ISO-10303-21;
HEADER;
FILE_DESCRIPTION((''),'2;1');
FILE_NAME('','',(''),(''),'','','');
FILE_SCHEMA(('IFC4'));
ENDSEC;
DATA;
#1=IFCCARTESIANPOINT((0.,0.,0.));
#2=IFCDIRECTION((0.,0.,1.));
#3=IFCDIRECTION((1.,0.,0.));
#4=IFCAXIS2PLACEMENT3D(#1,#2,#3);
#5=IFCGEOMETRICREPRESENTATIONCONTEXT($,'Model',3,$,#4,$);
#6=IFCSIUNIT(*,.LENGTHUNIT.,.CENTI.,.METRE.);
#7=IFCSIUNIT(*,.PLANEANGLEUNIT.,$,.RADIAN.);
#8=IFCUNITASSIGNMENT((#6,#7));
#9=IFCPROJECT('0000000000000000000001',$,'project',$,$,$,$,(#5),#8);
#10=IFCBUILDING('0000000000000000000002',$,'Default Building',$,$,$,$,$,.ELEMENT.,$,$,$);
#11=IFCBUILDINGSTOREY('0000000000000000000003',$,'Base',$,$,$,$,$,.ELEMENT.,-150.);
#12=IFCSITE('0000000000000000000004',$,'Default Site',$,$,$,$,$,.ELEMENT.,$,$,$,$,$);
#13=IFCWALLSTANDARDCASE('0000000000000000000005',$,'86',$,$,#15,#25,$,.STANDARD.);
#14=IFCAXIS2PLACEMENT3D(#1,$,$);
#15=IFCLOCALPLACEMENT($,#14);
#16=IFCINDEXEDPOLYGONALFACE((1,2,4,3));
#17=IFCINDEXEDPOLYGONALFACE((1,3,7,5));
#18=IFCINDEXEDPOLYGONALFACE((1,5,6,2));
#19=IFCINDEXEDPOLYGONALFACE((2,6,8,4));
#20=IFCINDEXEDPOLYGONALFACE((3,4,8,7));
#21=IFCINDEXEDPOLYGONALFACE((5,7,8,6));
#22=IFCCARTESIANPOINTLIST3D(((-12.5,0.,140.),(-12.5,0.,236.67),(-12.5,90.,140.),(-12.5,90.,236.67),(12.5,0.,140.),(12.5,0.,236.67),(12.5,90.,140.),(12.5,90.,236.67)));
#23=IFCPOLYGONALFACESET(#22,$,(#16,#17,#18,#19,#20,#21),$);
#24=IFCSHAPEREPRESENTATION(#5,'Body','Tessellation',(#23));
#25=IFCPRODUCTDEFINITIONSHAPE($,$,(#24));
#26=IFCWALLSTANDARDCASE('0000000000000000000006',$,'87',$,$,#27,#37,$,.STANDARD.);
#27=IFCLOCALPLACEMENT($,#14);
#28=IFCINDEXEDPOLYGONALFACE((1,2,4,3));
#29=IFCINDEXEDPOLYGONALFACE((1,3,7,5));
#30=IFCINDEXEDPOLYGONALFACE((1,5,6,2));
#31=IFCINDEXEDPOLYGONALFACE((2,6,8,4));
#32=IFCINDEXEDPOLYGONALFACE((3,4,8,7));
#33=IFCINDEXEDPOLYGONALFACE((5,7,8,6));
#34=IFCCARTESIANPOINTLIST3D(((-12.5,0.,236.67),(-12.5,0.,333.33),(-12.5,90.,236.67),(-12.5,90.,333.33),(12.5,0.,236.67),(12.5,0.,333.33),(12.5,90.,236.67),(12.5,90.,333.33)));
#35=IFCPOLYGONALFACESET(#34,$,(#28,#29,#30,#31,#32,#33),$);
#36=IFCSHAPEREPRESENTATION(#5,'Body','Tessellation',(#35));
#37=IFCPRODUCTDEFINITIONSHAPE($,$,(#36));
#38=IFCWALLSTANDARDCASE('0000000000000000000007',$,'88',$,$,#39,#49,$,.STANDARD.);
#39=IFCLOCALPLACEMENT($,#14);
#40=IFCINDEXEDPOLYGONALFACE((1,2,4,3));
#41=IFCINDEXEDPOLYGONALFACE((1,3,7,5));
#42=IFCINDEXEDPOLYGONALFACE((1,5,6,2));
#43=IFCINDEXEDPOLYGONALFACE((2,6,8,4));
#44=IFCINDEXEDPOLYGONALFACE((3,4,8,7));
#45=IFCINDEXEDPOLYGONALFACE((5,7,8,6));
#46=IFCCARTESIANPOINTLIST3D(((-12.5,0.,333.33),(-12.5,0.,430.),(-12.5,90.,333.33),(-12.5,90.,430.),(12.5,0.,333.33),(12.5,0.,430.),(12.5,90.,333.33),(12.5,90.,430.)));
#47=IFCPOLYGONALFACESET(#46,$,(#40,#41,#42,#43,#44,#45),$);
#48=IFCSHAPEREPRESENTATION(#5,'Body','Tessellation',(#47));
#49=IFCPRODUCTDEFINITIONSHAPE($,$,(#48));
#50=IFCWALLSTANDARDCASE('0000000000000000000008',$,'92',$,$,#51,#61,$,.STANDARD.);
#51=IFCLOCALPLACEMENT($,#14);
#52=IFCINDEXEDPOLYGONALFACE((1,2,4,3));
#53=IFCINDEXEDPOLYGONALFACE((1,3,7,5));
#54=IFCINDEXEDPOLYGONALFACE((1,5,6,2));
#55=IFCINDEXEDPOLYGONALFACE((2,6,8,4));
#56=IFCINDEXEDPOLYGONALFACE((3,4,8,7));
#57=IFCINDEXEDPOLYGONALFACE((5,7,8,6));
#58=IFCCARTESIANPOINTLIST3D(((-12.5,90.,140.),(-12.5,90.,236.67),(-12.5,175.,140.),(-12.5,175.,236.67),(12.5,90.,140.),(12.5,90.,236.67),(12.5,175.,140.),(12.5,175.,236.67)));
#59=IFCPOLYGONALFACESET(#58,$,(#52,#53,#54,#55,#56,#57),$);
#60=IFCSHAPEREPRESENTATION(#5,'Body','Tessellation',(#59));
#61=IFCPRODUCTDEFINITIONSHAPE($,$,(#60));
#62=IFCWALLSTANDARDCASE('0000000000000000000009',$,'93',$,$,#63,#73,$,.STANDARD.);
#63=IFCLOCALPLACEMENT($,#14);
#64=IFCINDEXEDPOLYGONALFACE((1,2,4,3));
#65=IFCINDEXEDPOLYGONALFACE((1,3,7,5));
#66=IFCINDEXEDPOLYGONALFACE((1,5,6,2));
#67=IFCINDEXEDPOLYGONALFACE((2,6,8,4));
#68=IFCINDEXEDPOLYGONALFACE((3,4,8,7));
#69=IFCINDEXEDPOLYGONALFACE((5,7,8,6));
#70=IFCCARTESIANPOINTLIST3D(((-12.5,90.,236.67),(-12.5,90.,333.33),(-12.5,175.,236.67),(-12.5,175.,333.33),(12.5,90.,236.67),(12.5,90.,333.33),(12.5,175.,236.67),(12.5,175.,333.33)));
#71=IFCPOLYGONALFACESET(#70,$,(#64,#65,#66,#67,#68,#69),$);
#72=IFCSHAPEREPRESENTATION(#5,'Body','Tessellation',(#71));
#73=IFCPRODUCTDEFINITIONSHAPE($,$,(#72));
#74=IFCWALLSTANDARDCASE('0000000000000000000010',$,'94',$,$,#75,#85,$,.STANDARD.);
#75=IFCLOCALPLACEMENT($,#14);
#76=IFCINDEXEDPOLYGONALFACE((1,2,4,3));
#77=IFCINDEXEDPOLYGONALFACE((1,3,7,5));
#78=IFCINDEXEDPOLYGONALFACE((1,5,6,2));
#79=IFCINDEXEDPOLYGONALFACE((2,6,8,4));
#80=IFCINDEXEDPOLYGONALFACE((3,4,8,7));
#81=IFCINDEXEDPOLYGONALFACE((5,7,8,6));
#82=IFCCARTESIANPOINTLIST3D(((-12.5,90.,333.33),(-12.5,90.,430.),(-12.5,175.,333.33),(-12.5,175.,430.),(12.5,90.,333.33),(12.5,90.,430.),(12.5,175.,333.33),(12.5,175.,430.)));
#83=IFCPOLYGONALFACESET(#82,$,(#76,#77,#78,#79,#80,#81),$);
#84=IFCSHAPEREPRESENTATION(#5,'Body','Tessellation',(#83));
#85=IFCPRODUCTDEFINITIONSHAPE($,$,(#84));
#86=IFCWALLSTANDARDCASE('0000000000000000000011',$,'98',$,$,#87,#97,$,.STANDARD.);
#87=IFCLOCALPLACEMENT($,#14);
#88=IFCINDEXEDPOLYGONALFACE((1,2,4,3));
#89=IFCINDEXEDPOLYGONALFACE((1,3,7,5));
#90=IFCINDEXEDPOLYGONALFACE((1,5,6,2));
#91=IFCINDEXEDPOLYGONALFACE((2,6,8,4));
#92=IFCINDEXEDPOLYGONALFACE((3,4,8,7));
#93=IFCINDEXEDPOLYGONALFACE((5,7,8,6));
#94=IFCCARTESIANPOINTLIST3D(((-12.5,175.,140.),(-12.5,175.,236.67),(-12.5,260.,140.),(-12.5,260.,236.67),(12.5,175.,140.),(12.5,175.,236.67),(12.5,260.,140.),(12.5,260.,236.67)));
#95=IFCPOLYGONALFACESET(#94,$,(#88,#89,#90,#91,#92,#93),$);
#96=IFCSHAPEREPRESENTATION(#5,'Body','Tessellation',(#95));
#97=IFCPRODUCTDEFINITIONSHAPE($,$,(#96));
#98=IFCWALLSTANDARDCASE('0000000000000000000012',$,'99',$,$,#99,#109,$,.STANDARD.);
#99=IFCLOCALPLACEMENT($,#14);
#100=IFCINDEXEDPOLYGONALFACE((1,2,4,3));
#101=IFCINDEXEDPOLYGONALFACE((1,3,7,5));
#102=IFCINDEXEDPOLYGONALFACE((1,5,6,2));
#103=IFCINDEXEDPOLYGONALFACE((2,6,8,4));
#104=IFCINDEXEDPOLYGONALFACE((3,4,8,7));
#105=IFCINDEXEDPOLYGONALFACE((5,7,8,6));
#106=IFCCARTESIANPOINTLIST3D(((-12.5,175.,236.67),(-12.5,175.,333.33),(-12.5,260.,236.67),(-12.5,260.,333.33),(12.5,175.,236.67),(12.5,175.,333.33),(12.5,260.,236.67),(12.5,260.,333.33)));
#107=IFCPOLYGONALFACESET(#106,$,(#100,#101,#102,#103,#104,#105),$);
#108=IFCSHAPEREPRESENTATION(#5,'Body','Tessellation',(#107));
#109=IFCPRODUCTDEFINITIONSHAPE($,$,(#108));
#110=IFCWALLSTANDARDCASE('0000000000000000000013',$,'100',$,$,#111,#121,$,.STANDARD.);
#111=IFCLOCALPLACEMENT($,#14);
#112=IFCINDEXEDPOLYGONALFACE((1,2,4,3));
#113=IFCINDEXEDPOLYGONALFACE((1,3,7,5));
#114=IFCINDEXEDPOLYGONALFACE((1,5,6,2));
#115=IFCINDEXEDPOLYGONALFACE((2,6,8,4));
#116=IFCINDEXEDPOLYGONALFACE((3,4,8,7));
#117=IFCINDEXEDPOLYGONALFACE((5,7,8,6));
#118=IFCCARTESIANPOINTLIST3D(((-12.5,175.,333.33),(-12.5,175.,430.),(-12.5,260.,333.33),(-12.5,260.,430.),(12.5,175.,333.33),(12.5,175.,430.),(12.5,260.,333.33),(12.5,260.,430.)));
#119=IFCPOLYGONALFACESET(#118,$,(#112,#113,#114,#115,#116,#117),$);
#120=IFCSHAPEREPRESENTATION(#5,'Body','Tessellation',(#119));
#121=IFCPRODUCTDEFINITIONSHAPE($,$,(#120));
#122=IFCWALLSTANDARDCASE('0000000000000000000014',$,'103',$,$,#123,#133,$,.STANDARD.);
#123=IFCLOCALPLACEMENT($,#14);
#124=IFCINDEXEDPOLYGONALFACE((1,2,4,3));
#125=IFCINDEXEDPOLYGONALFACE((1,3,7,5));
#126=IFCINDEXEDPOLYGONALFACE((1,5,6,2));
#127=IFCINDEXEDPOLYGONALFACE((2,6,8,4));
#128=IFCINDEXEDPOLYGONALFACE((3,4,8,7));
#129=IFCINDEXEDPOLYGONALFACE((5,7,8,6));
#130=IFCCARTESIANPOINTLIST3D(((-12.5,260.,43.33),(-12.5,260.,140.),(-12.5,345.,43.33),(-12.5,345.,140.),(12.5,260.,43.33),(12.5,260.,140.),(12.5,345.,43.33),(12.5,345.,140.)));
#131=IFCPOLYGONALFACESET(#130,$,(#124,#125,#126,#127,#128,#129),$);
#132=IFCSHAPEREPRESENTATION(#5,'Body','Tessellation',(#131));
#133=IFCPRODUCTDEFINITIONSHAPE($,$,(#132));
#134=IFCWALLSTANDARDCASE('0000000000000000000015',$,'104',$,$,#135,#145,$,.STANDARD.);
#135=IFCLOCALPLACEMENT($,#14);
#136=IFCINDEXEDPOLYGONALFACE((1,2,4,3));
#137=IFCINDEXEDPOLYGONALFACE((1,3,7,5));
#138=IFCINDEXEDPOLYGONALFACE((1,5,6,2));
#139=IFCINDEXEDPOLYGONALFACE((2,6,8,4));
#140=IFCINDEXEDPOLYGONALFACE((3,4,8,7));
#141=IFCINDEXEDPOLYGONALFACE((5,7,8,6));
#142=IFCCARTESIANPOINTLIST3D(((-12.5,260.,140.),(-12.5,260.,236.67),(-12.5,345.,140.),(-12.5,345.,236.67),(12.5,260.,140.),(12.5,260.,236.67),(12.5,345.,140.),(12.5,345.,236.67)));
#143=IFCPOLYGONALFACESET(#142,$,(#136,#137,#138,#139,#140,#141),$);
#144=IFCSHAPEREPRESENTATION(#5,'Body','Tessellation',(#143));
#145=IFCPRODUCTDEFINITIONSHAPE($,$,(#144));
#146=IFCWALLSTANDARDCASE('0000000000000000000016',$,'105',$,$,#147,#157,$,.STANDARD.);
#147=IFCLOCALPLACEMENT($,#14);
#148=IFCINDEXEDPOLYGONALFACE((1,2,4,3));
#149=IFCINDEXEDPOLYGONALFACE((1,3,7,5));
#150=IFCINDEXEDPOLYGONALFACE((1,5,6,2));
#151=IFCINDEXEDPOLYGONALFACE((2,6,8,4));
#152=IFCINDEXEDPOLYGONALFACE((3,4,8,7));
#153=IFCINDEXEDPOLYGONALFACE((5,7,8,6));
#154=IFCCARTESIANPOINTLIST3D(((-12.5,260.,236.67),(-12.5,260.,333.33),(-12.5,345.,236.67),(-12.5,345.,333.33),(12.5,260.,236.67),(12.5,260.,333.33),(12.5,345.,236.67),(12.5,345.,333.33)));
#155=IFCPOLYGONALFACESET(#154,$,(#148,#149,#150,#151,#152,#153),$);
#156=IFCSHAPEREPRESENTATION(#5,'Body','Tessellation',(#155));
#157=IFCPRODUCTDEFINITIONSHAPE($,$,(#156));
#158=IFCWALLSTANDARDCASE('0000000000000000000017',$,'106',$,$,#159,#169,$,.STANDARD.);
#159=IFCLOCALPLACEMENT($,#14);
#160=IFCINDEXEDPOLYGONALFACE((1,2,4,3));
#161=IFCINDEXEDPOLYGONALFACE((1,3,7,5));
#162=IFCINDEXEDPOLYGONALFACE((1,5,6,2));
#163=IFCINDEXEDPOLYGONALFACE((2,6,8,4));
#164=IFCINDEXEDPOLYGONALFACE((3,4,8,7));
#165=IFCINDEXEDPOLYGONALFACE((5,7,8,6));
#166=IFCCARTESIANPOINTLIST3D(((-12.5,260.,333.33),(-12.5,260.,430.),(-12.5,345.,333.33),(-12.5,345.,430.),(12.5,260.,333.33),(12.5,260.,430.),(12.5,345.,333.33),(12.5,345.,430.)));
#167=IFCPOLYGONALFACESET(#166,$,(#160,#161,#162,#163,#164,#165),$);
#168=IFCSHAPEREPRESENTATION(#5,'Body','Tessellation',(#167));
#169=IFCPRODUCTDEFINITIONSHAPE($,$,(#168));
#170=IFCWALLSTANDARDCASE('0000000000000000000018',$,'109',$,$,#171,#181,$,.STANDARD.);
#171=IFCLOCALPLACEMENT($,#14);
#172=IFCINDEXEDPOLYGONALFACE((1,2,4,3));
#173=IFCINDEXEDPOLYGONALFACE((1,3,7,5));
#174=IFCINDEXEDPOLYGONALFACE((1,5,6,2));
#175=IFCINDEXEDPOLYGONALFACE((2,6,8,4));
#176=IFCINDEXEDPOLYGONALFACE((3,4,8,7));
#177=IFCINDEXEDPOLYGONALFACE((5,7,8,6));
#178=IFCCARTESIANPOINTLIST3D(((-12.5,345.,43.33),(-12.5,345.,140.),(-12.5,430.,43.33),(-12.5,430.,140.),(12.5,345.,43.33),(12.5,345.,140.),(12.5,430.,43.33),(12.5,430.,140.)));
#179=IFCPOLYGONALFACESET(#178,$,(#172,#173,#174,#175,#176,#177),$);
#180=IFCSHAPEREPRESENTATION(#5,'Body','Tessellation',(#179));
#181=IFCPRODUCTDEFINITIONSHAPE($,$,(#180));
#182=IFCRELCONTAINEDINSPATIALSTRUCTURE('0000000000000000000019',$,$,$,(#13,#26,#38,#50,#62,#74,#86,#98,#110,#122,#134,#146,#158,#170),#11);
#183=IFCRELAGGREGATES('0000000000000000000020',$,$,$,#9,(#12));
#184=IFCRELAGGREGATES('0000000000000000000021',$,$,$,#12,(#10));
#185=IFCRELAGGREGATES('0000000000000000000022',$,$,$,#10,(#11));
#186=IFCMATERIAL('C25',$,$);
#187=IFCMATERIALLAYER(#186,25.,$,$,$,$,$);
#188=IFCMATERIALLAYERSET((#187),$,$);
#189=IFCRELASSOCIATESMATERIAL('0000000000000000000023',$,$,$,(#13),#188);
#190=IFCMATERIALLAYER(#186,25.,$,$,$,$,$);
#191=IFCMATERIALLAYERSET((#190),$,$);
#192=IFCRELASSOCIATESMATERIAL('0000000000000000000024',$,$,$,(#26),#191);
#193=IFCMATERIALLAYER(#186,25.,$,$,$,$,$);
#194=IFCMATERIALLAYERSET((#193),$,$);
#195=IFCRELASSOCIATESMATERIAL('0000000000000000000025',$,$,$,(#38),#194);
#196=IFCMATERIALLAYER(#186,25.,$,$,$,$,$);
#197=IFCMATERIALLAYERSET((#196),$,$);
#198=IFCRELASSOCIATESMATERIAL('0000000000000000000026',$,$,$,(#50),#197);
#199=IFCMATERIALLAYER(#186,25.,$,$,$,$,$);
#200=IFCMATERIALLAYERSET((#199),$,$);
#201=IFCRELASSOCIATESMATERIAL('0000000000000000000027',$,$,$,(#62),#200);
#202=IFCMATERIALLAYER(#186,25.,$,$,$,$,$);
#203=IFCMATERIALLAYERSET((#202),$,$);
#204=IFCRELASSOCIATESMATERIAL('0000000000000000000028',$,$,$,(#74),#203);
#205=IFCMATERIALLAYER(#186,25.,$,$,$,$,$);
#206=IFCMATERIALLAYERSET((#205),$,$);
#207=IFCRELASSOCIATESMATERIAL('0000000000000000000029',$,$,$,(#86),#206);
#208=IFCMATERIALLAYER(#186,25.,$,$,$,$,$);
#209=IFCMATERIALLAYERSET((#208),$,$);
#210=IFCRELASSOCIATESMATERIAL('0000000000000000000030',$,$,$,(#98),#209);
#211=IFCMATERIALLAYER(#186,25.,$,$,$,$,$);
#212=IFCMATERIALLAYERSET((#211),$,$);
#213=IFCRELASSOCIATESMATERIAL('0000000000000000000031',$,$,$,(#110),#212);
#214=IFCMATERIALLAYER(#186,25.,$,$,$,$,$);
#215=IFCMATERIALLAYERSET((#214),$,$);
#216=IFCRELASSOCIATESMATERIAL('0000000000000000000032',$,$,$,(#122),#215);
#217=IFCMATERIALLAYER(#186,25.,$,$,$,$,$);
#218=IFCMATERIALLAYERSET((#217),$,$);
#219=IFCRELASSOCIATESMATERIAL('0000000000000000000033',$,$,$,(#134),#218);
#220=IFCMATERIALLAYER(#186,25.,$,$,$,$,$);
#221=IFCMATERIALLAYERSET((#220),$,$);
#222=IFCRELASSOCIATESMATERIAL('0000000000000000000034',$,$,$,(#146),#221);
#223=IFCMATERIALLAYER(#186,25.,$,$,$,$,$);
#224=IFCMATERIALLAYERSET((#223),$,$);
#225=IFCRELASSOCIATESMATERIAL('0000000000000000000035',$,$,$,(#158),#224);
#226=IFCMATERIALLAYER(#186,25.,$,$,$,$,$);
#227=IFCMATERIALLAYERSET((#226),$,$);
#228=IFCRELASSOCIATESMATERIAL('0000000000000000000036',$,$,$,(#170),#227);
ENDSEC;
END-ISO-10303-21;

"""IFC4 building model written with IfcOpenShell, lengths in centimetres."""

from ifc_helpers import new_model, si_unit, frame, origin_with_axes, origin_2d_with_axis, place, context, project, spatial, rectangle, extrude, material, layer, layer_set, layer_usage, element, save


model = new_model("IFC4")

# Units and contexts
model_context = context("Model", 3, world=origin_with_axes())
ifc_project = project(units=[si_unit("LENGTHUNIT", "METRE", prefix="CENTI"), si_unit("PLANEANGLEUNIT", "RADIAN")], contexts=[model_context])

# Site, building, storey
site = spatial("IfcSite", under=ifc_project, Name="Default Site", CompositionType="ELEMENT")
building = spatial("IfcBuilding", under=site, Name="Default Building", CompositionType="ELEMENT")
storey = spatial("IfcBuildingStorey", under=building, Name="Base", CompositionType="ELEMENT", Elevation=-150.0)

# Walls
ifc_material = material(Name="C25")
ifc_layer_1 = layer(ifc_material, 25.0)
ifc_layer_set_1 = layer_set([ifc_layer_1])
ifc_layer_usage_1 = layer_usage(ifc_layer_set_1, "AXIS2", "POSITIVE", -25.0)
wall_1_placement = place(None, frame((0.0, 45.0, 140.0), z_axis=(0.0, 0.0, 1.0), x_axis=(0.0, 1.0, 0.0)))
element("IfcWallStandardCase", 1, at=wall_1_placement, inside=storey, material=ifc_layer_usage_1, Name="86", PredefinedType="STANDARD", context=model_context, shape_type="SweptSolid", body=[
    extrude(rectangle(XDim=90.0, YDim=25.0, at=origin_2d_with_axis()), origin_with_axes(), (0.0, 0.0, 1.0), 96.67),
])
ifc_layer_2 = layer(ifc_material, 25.0)
ifc_layer_set_2 = layer_set([ifc_layer_2])
ifc_layer_usage_2 = layer_usage(ifc_layer_set_2, "AXIS2", "POSITIVE", -25.0)
wall_2_placement = place(None, frame((0.0, 45.0, 236.67), z_axis=(0.0, 0.0, 1.0), x_axis=(0.0, 1.0, 0.0)))
element("IfcWallStandardCase", 2, at=wall_2_placement, inside=storey, material=ifc_layer_usage_2, Name="87", PredefinedType="STANDARD", context=model_context, shape_type="SweptSolid", body=[
    extrude(rectangle(XDim=90.0, YDim=25.0, at=origin_2d_with_axis()), origin_with_axes(), (0.0, 0.0, 1.0), 96.67),
])
ifc_layer_3 = layer(ifc_material, 25.0)
ifc_layer_set_3 = layer_set([ifc_layer_3])
ifc_layer_usage_3 = layer_usage(ifc_layer_set_3, "AXIS2", "POSITIVE", -25.0)
wall_3_placement = place(None, frame((0.0, 45.0, 333.33), z_axis=(0.0, 0.0, 1.0), x_axis=(0.0, 1.0, 0.0)))
element("IfcWallStandardCase", 3, at=wall_3_placement, inside=storey, material=ifc_layer_usage_3, Name="88", PredefinedType="STANDARD", context=model_context, shape_type="SweptSolid", body=[
    extrude(rectangle(XDim=90.0, YDim=25.0, at=origin_2d_with_axis()), origin_with_axes(), (0.0, 0.0, 1.0), 96.67),
])
ifc_layer_4 = layer(ifc_material, 25.0)
ifc_layer_set_4 = layer_set([ifc_layer_4])
ifc_layer_usage_4 = layer_usage(ifc_layer_set_4, "AXIS2", "POSITIVE", -25.0)
wall_4_placement = place(None, frame((0.0, 132.5, 140.0), z_axis=(0.0, 0.0, 1.0), x_axis=(0.0, 1.0, 0.0)))
element("IfcWallStandardCase", 4, at=wall_4_placement, inside=storey, material=ifc_layer_usage_4, Name="92", PredefinedType="STANDARD", context=model_context, shape_type="SweptSolid", body=[
    extrude(rectangle(XDim=85.0, YDim=25.0, at=origin_2d_with_axis()), origin_with_axes(), (0.0, 0.0, 1.0), 96.67),
])
ifc_layer_5 = layer(ifc_material, 25.0)
ifc_layer_set_5 = layer_set([ifc_layer_5])
ifc_layer_usage_5 = layer_usage(ifc_layer_set_5, "AXIS2", "POSITIVE", -25.0)
wall_5_placement = place(None, frame((0.0, 132.5, 236.67), z_axis=(0.0, 0.0, 1.0), x_axis=(0.0, 1.0, 0.0)))
element("IfcWallStandardCase", 5, at=wall_5_placement, inside=storey, material=ifc_layer_usage_5, Name="93", PredefinedType="STANDARD", context=model_context, shape_type="SweptSolid", body=[
    extrude(rectangle(XDim=85.0, YDim=25.0, at=origin_2d_with_axis()), origin_with_axes(), (0.0, 0.0, 1.0), 96.67),
])
ifc_layer_6 = layer(ifc_material, 25.0)
ifc_layer_set_6 = layer_set([ifc_layer_6])
ifc_layer_usage_6 = layer_usage(ifc_layer_set_6, "AXIS2", "POSITIVE", -25.0)
wall_6_placement = place(None, frame((0.0, 132.5, 333.33), z_axis=(0.0, 0.0, 1.0), x_axis=(0.0, 1.0, 0.0)))
element("IfcWallStandardCase", 6, at=wall_6_placement, inside=storey, material=ifc_layer_usage_6, Name="94", PredefinedType="STANDARD", context=model_context, shape_type="SweptSolid", body=[
    extrude(rectangle(XDim=85.0, YDim=25.0, at=origin_2d_with_axis()), origin_with_axes(), (0.0, 0.0, 1.0), 96.67),
])
ifc_layer_7 = layer(ifc_material, 25.0)
ifc_layer_set_7 = layer_set([ifc_layer_7])
ifc_layer_usage_7 = layer_usage(ifc_layer_set_7, "AXIS2", "POSITIVE", -25.0)
wall_7_placement = place(None, frame((0.0, 217.5, 140.0), z_axis=(0.0, 0.0, 1.0), x_axis=(0.0, 1.0, 0.0)))
element("IfcWallStandardCase", 7, at=wall_7_placement, inside=storey, material=ifc_layer_usage_7, Name="98", PredefinedType="STANDARD", context=model_context, shape_type="SweptSolid", body=[
    extrude(rectangle(XDim=85.0, YDim=25.0, at=origin_2d_with_axis()), origin_with_axes(), (0.0, 0.0, 1.0), 96.67),
])
ifc_layer_8 = layer(ifc_material, 25.0)
ifc_layer_set_8 = layer_set([ifc_layer_8])
ifc_layer_usage_8 = layer_usage(ifc_layer_set_8, "AXIS2", "POSITIVE", -25.0)
wall_8_placement = place(None, frame((0.0, 217.5, 236.67), z_axis=(0.0, 0.0, 1.0), x_axis=(0.0, 1.0, 0.0)))
element("IfcWallStandardCase", 8, at=wall_8_placement, inside=storey, material=ifc_layer_usage_8, Name="99", PredefinedType="STANDARD", context=model_context, shape_type="SweptSolid", body=[
    extrude(rectangle(XDim=85.0, YDim=25.0, at=origin_2d_with_axis()), origin_with_axes(), (0.0, 0.0, 1.0), 96.67),
])
ifc_layer_9 = layer(ifc_material, 25.0)
ifc_layer_set_9 = layer_set([ifc_layer_9])
ifc_layer_usage_9 = layer_usage(ifc_layer_set_9, "AXIS2", "POSITIVE", -25.0)
wall_9_placement = place(None, frame((0.0, 217.5, 333.33), z_axis=(0.0, 0.0, 1.0), x_axis=(0.0, 1.0, 0.0)))
element("IfcWallStandardCase", 9, at=wall_9_placement, inside=storey, material=ifc_layer_usage_9, Name="100", PredefinedType="STANDARD", context=model_context, shape_type="SweptSolid", body=[
    extrude(rectangle(XDim=85.0, YDim=25.0, at=origin_2d_with_axis()), origin_with_axes(), (0.0, 0.0, 1.0), 96.67),
])
ifc_layer_10 = layer(ifc_material, 25.0)
ifc_layer_set_10 = layer_set([ifc_layer_10])
ifc_layer_usage_10 = layer_usage(ifc_layer_set_10, "AXIS2", "POSITIVE", -25.0)
wall_10_placement = place(None, frame((0.0, 302.5, 43.33), z_axis=(0.0, 0.0, 1.0), x_axis=(0.0, 1.0, 0.0)))
element("IfcWallStandardCase", 10, at=wall_10_placement, inside=storey, material=ifc_layer_usage_10, Name="103", PredefinedType="STANDARD", context=model_context, shape_type="SweptSolid", body=[
    extrude(rectangle(XDim=85.0, YDim=25.0, at=origin_2d_with_axis()), origin_with_axes(), (0.0, 0.0, 1.0), 96.67),
])
ifc_layer_11 = layer(ifc_material, 25.0)
ifc_layer_set_11 = layer_set([ifc_layer_11])
ifc_layer_usage_11 = layer_usage(ifc_layer_set_11, "AXIS2", "POSITIVE", -25.0)
wall_11_placement = place(None, frame((0.0, 302.5, 140.0), z_axis=(0.0, 0.0, 1.0), x_axis=(0.0, 1.0, 0.0)))
element("IfcWallStandardCase", 11, at=wall_11_placement, inside=storey, material=ifc_layer_usage_11, Name="104", PredefinedType="STANDARD", context=model_context, shape_type="SweptSolid", body=[
    extrude(rectangle(XDim=85.0, YDim=25.0, at=origin_2d_with_axis()), origin_with_axes(), (0.0, 0.0, 1.0), 96.67),
])
ifc_layer_12 = layer(ifc_material, 25.0)
ifc_layer_set_12 = layer_set([ifc_layer_12])
ifc_layer_usage_12 = layer_usage(ifc_layer_set_12, "AXIS2", "POSITIVE", -25.0)
wall_12_placement = place(None, frame((0.0, 302.5, 236.67), z_axis=(0.0, 0.0, 1.0), x_axis=(0.0, 1.0, 0.0)))
element("IfcWallStandardCase", 12, at=wall_12_placement, inside=storey, material=ifc_layer_usage_12, Name="105", PredefinedType="STANDARD", context=model_context, shape_type="SweptSolid", body=[
    extrude(rectangle(XDim=85.0, YDim=25.0, at=origin_2d_with_axis()), origin_with_axes(), (0.0, 0.0, 1.0), 96.67),
])
ifc_layer_13 = layer(ifc_material, 25.0)
ifc_layer_set_13 = layer_set([ifc_layer_13])
ifc_layer_usage_13 = layer_usage(ifc_layer_set_13, "AXIS2", "POSITIVE", -25.0)
wall_13_placement = place(None, frame((0.0, 302.5, 333.33), z_axis=(0.0, 0.0, 1.0), x_axis=(0.0, 1.0, 0.0)))
element("IfcWallStandardCase", 13, at=wall_13_placement, inside=storey, material=ifc_layer_usage_13, Name="106", PredefinedType="STANDARD", context=model_context, shape_type="SweptSolid", body=[
    extrude(rectangle(XDim=85.0, YDim=25.0, at=origin_2d_with_axis()), origin_with_axes(), (0.0, 0.0, 1.0), 96.67),
])
ifc_layer_14 = layer(ifc_material, 25.0)
ifc_layer_set_14 = layer_set([ifc_layer_14])
ifc_layer_usage_14 = layer_usage(ifc_layer_set_14, "AXIS2", "POSITIVE", -25.0)
wall_14_placement = place(None, frame((0.0, 387.5, 43.33), z_axis=(0.0, 0.0, 1.0), x_axis=(0.0, 1.0, 0.0)))
element("IfcWallStandardCase", 14, at=wall_14_placement, inside=storey, material=ifc_layer_usage_14, Name="109", PredefinedType="STANDARD", context=model_context, shape_type="SweptSolid", body=[
    extrude(rectangle(XDim=85.0, YDim=25.0, at=origin_2d_with_axis()), origin_with_axes(), (0.0, 0.0, 1.0), 96.67),
])

save(model, "model.ifc")
